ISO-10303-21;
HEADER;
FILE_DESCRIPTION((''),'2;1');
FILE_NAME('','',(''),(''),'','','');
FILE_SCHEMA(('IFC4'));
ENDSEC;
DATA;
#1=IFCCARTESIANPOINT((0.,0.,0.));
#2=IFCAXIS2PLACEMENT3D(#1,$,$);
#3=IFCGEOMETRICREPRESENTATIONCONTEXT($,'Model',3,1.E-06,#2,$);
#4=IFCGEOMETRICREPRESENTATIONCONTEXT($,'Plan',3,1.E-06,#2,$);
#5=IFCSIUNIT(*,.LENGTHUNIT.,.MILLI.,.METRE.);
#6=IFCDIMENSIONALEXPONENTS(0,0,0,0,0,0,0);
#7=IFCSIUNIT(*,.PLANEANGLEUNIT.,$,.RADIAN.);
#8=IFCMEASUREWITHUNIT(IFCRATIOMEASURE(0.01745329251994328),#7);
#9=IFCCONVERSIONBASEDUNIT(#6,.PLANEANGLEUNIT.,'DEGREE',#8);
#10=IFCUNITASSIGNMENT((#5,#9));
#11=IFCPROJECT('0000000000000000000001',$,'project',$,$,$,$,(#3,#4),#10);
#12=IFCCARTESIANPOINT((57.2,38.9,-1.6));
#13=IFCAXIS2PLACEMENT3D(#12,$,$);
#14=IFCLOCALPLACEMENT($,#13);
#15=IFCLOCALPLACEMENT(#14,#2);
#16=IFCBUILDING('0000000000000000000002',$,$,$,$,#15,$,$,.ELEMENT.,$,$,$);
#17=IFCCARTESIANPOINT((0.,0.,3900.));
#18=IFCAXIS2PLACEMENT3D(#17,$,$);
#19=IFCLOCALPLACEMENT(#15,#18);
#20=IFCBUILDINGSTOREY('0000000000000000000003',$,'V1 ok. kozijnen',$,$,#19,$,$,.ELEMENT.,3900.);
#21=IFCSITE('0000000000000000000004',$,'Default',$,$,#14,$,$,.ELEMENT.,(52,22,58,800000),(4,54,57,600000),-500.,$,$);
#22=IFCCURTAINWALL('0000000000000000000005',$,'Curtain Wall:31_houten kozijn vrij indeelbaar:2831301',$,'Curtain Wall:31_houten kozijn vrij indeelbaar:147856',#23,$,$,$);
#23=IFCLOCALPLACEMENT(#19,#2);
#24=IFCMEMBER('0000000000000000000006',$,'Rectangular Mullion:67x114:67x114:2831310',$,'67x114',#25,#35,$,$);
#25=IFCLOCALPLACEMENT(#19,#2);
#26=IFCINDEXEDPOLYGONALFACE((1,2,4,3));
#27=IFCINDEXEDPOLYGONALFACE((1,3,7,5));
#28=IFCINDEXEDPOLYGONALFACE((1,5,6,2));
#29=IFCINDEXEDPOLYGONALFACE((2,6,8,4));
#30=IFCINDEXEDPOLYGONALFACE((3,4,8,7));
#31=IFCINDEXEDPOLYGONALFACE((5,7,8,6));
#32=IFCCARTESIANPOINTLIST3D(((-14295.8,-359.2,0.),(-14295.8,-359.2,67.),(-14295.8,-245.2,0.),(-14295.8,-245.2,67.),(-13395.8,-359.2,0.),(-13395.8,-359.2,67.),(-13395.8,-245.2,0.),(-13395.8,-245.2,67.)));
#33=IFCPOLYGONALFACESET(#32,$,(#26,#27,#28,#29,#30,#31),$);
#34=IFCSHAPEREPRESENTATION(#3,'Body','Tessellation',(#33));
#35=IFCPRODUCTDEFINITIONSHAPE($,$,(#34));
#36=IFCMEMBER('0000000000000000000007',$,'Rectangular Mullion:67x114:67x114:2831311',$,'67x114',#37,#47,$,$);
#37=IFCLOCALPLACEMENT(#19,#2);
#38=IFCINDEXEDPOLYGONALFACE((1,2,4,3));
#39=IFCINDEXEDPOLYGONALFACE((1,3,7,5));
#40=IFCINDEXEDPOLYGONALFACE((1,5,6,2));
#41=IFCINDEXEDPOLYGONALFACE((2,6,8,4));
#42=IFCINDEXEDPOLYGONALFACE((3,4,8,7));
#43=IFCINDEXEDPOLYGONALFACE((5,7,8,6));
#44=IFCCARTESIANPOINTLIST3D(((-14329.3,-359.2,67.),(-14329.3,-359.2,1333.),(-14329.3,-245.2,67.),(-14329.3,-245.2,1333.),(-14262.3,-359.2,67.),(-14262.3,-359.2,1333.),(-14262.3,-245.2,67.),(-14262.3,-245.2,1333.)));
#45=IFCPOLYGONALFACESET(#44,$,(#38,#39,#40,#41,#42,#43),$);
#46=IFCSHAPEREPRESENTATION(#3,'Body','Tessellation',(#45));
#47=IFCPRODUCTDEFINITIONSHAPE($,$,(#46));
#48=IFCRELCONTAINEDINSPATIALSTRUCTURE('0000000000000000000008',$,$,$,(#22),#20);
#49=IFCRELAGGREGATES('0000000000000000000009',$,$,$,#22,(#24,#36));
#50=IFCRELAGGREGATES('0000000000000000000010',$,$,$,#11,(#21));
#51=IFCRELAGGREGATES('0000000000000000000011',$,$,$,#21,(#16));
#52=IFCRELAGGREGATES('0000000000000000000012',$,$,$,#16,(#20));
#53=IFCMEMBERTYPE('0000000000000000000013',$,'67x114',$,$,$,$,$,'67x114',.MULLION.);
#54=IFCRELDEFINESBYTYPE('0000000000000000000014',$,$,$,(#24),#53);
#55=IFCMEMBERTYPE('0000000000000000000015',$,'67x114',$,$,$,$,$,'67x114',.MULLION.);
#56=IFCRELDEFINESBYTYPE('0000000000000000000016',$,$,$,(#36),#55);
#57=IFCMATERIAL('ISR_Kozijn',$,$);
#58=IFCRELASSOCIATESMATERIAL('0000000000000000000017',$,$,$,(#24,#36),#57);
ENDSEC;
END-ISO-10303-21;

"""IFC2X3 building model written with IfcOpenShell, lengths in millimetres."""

from ifc_helpers import new_model, entity, si_unit, converted_unit, frame, origin, origin_2d_with_axis, place, context, project, spatial, rectangle, extrude, source, transform, mapped, material, type_object, type_shapes, element, aggregate, save


model = new_model("IFC2X3")

# Units and contexts
model_context = context("Model", 3, precision=1e-06, world=origin())
plan_context = context("Plan", 3, precision=1e-06, world=origin())
ifc_project = project(units=[si_unit("LENGTHUNIT", "METRE", prefix="MILLI"), converted_unit("PLANEANGLEUNIT", "DEGREE", entity("IfcRatioMeasure", 0.01745329251994328), si_unit("PLANEANGLEUNIT", "RADIAN"), dimensions=[0, 0, 0, 0, 0, 0, 0])], contexts=[model_context, plan_context])

# Site, building, storey
site_placement = place(None, frame((57.2, 38.9, -1.6)))
site = spatial("IfcSite", under=ifc_project, at=site_placement, Name="Default", CompositionType="ELEMENT", RefLatitude=(52, 22, 58, 800000), RefLongitude=(4, 54, 57, 600000), RefElevation=-500.0)
building_placement = place(site_placement, origin())
building = spatial("IfcBuilding", under=site, at=building_placement, CompositionType="ELEMENT")
storey_placement = place(building_placement, frame((0.0, 0.0, 3900.0)))
storey = spatial("IfcBuildingStorey", under=building, at=storey_placement, Name="V1 ok. kozijnen", CompositionType="ELEMENT", Elevation=3900.0)

# Curtain wall, members
ifc_material_1 = material(Name="ISR_Kozijn")
curtain_wall_1_placement = place(storey_placement, origin())
curtain_wall_1 = element("IfcCurtainWall", 1, at=curtain_wall_1_placement, inside=storey, Name="Curtain Wall:31_houten kozijn vrij indeelbaar:2831301", ObjectType="Curtain Wall:31_houten kozijn vrij indeelbaar:147856")
member_type_1 = type_object("IfcMemberType", Name="67x114", ElementType="67x114", PredefinedType="MULLION")
shared_shape_1 = source(origin(), model_context, "Body", "SweptSolid", [
    extrude(rectangle(XDim=67.0, YDim=114.0, at=origin_2d_with_axis()), frame((-33.5, -57.0, -900.0), z_axis=(0.0, 0.0, 1.0), x_axis=(-1.0, 0.0, 0.0)), (0.0, 0.0, 1.0), 900.0),
])
type_shapes(member_type_1, [shared_shape_1])
member_1_placement = place(storey_placement, frame((-14295.8, -359.2, 0.0), z_axis=(-1.0, 0.0, 0.0), x_axis=(0.0, 0.0, -1.0)))
member_1 = element("IfcMember", 2, at=member_1_placement, type_object=member_type_1, material=ifc_material_1, Name="Rectangular Mullion:67x114:67x114:2831310", ObjectType="67x114", context=model_context, shape_type="MappedRepresentation", body=[
    mapped(shared_shape_1, transform((0.0, 0.0, 0.0), scale=1.0)),
])
member_type_2 = type_object("IfcMemberType", Name="67x114", ElementType="67x114", PredefinedType="MULLION")
shared_shape_2 = source(origin(), model_context, "Body", "SweptSolid", [
    extrude(rectangle(XDim=67.0, YDim=114.0, at=origin_2d_with_axis()), frame((0.0, -57.0, -1266.0), z_axis=(0.0, 0.0, 1.0), x_axis=(-1.0, 0.0, 0.0)), (0.0, 0.0, 1.0), 1266.0),
])
type_shapes(member_type_2, [shared_shape_2])
member_2_placement = place(storey_placement, frame((-14295.8, -359.2, 67.0), z_axis=(0.0, 0.0, -1.0), x_axis=(1.0, 0.0, 0.0)))
member_2 = element("IfcMember", 3, at=member_2_placement, type_object=member_type_2, material=ifc_material_1, Name="Rectangular Mullion:67x114:67x114:2831311", ObjectType="67x114", context=model_context, shape_type="MappedRepresentation", body=[
    mapped(shared_shape_2, transform((0.0, 0.0, 0.0), scale=1.0)),
])

aggregate(curtain_wall_1, [member_1, member_2])

save(model, "model.ifc")
